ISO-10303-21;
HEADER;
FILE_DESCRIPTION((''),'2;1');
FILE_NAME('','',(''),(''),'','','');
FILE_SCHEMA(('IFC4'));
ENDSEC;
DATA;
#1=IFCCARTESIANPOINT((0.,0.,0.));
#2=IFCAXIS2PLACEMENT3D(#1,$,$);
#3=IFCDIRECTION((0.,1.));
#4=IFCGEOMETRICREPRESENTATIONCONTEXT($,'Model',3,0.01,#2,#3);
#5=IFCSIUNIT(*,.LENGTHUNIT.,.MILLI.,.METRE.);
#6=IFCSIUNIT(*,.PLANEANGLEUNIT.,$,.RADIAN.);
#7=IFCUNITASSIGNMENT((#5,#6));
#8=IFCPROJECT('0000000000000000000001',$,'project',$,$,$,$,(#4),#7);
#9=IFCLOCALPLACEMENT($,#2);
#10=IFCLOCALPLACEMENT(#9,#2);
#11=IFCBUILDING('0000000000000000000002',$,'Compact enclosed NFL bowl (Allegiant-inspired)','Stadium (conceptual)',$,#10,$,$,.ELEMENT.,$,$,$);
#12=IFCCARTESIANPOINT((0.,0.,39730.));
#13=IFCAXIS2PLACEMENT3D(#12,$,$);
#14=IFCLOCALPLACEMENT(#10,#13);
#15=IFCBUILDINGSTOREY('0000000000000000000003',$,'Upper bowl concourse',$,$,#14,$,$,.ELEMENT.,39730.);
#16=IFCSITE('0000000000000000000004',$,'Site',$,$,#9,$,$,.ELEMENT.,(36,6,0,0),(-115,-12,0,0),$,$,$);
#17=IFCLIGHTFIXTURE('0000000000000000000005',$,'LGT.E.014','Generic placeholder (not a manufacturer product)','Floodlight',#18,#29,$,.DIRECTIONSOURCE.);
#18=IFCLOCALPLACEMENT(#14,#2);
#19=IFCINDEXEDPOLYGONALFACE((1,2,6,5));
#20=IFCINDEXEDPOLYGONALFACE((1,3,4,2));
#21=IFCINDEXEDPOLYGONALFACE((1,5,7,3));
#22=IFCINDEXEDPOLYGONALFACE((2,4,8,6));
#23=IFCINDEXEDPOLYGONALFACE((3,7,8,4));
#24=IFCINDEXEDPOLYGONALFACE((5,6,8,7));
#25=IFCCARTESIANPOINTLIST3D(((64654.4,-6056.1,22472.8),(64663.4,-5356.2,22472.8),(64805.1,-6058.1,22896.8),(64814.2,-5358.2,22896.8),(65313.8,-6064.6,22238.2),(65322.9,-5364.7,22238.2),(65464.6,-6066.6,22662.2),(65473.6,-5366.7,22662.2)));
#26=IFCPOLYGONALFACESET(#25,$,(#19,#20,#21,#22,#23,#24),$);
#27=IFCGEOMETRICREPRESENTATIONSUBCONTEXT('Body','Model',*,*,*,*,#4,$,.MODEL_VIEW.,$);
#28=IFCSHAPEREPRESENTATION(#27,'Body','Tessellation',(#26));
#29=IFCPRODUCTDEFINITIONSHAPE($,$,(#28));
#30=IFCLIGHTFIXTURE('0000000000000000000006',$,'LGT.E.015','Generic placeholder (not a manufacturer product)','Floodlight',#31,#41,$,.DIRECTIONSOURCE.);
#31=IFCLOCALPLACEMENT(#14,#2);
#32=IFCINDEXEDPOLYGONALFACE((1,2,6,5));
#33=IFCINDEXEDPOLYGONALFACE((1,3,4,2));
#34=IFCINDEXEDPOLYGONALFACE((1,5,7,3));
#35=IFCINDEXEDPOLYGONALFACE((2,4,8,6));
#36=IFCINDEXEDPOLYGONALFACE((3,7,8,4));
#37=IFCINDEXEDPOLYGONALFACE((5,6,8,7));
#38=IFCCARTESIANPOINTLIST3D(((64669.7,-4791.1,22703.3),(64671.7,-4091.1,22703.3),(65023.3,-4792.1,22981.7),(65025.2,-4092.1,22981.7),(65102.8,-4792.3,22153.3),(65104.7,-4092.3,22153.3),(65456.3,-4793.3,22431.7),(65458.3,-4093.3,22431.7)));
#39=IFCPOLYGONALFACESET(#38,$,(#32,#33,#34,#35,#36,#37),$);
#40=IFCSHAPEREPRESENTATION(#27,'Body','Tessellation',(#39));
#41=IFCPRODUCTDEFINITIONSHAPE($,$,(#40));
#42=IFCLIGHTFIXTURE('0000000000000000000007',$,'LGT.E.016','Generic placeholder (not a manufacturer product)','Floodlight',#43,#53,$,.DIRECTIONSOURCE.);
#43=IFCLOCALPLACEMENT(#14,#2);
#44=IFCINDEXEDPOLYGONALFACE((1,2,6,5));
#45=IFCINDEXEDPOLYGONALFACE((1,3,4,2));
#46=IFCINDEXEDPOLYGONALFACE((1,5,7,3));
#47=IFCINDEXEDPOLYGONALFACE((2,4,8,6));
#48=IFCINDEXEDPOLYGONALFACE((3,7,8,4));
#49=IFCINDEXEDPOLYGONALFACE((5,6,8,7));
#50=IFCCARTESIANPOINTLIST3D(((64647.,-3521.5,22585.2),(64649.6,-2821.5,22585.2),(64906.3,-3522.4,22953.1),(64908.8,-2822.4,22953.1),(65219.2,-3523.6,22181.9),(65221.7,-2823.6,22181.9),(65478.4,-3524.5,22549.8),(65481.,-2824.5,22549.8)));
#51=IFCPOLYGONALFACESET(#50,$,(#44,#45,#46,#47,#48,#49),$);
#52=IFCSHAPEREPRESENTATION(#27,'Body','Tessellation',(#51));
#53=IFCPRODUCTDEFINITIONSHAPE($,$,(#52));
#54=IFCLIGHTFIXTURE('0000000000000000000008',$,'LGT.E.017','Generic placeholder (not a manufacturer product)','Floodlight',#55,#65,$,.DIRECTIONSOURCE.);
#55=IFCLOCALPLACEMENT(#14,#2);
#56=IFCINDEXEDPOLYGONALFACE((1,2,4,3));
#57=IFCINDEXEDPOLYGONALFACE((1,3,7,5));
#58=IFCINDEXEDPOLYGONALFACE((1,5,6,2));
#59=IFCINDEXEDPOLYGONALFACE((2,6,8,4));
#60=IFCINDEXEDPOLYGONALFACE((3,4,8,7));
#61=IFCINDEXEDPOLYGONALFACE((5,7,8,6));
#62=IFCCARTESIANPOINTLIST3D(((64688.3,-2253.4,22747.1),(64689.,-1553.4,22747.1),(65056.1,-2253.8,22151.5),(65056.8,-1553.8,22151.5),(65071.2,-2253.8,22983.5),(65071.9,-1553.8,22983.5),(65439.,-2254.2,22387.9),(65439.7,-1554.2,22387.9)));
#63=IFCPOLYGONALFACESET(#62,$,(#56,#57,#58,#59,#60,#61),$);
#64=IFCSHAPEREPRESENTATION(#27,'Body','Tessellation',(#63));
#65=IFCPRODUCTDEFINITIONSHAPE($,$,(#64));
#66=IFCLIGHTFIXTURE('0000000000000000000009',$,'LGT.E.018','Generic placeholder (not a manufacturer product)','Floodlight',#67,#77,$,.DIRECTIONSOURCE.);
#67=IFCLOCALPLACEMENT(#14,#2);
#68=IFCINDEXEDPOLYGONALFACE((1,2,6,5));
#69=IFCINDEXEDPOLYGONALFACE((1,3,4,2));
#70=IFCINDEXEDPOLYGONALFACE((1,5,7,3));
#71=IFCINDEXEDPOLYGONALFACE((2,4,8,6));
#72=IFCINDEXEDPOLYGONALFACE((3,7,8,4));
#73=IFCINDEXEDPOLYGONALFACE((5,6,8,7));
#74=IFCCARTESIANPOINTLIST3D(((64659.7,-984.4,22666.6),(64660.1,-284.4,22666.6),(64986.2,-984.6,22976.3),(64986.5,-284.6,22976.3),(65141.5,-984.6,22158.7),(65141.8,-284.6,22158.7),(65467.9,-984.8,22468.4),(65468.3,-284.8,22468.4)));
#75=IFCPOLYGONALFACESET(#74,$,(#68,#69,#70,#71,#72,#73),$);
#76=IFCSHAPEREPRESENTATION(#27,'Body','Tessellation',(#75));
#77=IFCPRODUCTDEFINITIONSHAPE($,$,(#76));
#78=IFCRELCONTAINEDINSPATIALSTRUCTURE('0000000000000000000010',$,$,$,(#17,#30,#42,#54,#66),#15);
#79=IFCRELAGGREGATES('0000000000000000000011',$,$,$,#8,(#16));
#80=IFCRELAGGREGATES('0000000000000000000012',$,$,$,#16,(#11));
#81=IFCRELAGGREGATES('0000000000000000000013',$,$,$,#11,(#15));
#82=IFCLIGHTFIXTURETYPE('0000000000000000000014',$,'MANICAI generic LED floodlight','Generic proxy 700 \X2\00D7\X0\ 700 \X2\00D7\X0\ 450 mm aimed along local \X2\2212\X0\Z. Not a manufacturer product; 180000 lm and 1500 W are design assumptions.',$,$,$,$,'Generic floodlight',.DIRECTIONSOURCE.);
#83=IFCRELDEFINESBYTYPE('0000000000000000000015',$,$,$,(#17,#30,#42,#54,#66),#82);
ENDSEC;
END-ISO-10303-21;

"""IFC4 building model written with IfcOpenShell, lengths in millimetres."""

from ifc_helpers import new_model, si_unit, direction, frame, origin, place, context, subcontext, project, spatial, rectangle, extrude, source, transform, mapped, type_object, type_shapes, element, save


model = new_model("IFC4")

# Units and contexts
model_context = context("Model", 3, precision=0.01, world=origin(), true_north=direction((0.0, 1.0)))
body_context = subcontext(model_context, "Body", "Model", "MODEL_VIEW")
ifc_project = project(units=[si_unit("LENGTHUNIT", "METRE", prefix="MILLI"), si_unit("PLANEANGLEUNIT", "RADIAN")], contexts=[model_context])

# Site, building, storey
site_placement = place(None, origin())
site = spatial("IfcSite", under=ifc_project, at=site_placement, Name="Site", CompositionType="ELEMENT", RefLatitude=(36, 6, 0, 0), RefLongitude=(-115, -12, 0, 0))
building_placement = place(site_placement, origin())
building = spatial("IfcBuilding", under=site, at=building_placement, Name="Compact enclosed NFL bowl (Allegiant-inspired)", Description="Stadium (conceptual)", CompositionType="ELEMENT")
storey_placement = place(building_placement, frame((0.0, 0.0, 39730.0)))
storey = spatial("IfcBuildingStorey", under=building, at=storey_placement, Name="Upper bowl concourse", CompositionType="ELEMENT", Elevation=39730.0)

# Light fixtures
light_fixture_type = type_object("IfcLightFixtureType", Name="MANICAI generic LED floodlight", Description="Generic proxy 700 × 700 × 450 mm aimed along local −Z. Not a manufacturer product; 180000 lm and 1500 W are design assumptions.", ElementType="Generic floodlight", PredefinedType="DIRECTIONSOURCE")
shared_shape = source(origin(), body_context, "Body", "SweptSolid", [
    extrude(rectangle(XDim=700.0, YDim=700.0), frame((0.0, 0.0, -225.0)), (0.0, 0.0, 1.0), 450.0),
])
type_shapes(light_fixture_type, [shared_shape])
for number, where, z_axis, x_axis, name in (
    (1, (65064.0, -5711.4, 22567.5), (0.335041, -0.004319, 0.942194), (0.01289, 0.999917, 0.0), "LGT.E.014"),
    (2, (65064.0, -4442.2, 22567.5), (0.785672, -0.002206, 0.618639), (0.002807, 0.999996, 0.0), "LGT.E.015"),
    (3, (65064.0, -3173.0, 22567.5), (0.576129, -0.002082, 0.817356), (0.003613, 0.999993, 0.0), "LGT.E.016"),
    (4, (65064.0, -1903.8, 22567.5), (0.850831, -0.000803, 0.52544), (0.000944, 1.0, 0.0), "LGT.E.017"),
    (5, (65064.0, -634.6, 22567.5), (0.725492, -0.000351, 0.688231), (0.000483, 1.0, 0.0), "LGT.E.018"),
):
    element("IfcLightFixture", number, at=place(storey_placement, frame(where, z_axis=z_axis, x_axis=x_axis)), inside=storey, type_object=light_fixture_type, Name=name, Description="Generic placeholder (not a manufacturer product)", ObjectType="Floodlight", PredefinedType="DIRECTIONSOURCE", context=body_context, shape_type="MappedRepresentation", body=[
        mapped(shared_shape, transform((0.0, 0.0, 0.0))),
    ])

save(model, "model.ifc")
